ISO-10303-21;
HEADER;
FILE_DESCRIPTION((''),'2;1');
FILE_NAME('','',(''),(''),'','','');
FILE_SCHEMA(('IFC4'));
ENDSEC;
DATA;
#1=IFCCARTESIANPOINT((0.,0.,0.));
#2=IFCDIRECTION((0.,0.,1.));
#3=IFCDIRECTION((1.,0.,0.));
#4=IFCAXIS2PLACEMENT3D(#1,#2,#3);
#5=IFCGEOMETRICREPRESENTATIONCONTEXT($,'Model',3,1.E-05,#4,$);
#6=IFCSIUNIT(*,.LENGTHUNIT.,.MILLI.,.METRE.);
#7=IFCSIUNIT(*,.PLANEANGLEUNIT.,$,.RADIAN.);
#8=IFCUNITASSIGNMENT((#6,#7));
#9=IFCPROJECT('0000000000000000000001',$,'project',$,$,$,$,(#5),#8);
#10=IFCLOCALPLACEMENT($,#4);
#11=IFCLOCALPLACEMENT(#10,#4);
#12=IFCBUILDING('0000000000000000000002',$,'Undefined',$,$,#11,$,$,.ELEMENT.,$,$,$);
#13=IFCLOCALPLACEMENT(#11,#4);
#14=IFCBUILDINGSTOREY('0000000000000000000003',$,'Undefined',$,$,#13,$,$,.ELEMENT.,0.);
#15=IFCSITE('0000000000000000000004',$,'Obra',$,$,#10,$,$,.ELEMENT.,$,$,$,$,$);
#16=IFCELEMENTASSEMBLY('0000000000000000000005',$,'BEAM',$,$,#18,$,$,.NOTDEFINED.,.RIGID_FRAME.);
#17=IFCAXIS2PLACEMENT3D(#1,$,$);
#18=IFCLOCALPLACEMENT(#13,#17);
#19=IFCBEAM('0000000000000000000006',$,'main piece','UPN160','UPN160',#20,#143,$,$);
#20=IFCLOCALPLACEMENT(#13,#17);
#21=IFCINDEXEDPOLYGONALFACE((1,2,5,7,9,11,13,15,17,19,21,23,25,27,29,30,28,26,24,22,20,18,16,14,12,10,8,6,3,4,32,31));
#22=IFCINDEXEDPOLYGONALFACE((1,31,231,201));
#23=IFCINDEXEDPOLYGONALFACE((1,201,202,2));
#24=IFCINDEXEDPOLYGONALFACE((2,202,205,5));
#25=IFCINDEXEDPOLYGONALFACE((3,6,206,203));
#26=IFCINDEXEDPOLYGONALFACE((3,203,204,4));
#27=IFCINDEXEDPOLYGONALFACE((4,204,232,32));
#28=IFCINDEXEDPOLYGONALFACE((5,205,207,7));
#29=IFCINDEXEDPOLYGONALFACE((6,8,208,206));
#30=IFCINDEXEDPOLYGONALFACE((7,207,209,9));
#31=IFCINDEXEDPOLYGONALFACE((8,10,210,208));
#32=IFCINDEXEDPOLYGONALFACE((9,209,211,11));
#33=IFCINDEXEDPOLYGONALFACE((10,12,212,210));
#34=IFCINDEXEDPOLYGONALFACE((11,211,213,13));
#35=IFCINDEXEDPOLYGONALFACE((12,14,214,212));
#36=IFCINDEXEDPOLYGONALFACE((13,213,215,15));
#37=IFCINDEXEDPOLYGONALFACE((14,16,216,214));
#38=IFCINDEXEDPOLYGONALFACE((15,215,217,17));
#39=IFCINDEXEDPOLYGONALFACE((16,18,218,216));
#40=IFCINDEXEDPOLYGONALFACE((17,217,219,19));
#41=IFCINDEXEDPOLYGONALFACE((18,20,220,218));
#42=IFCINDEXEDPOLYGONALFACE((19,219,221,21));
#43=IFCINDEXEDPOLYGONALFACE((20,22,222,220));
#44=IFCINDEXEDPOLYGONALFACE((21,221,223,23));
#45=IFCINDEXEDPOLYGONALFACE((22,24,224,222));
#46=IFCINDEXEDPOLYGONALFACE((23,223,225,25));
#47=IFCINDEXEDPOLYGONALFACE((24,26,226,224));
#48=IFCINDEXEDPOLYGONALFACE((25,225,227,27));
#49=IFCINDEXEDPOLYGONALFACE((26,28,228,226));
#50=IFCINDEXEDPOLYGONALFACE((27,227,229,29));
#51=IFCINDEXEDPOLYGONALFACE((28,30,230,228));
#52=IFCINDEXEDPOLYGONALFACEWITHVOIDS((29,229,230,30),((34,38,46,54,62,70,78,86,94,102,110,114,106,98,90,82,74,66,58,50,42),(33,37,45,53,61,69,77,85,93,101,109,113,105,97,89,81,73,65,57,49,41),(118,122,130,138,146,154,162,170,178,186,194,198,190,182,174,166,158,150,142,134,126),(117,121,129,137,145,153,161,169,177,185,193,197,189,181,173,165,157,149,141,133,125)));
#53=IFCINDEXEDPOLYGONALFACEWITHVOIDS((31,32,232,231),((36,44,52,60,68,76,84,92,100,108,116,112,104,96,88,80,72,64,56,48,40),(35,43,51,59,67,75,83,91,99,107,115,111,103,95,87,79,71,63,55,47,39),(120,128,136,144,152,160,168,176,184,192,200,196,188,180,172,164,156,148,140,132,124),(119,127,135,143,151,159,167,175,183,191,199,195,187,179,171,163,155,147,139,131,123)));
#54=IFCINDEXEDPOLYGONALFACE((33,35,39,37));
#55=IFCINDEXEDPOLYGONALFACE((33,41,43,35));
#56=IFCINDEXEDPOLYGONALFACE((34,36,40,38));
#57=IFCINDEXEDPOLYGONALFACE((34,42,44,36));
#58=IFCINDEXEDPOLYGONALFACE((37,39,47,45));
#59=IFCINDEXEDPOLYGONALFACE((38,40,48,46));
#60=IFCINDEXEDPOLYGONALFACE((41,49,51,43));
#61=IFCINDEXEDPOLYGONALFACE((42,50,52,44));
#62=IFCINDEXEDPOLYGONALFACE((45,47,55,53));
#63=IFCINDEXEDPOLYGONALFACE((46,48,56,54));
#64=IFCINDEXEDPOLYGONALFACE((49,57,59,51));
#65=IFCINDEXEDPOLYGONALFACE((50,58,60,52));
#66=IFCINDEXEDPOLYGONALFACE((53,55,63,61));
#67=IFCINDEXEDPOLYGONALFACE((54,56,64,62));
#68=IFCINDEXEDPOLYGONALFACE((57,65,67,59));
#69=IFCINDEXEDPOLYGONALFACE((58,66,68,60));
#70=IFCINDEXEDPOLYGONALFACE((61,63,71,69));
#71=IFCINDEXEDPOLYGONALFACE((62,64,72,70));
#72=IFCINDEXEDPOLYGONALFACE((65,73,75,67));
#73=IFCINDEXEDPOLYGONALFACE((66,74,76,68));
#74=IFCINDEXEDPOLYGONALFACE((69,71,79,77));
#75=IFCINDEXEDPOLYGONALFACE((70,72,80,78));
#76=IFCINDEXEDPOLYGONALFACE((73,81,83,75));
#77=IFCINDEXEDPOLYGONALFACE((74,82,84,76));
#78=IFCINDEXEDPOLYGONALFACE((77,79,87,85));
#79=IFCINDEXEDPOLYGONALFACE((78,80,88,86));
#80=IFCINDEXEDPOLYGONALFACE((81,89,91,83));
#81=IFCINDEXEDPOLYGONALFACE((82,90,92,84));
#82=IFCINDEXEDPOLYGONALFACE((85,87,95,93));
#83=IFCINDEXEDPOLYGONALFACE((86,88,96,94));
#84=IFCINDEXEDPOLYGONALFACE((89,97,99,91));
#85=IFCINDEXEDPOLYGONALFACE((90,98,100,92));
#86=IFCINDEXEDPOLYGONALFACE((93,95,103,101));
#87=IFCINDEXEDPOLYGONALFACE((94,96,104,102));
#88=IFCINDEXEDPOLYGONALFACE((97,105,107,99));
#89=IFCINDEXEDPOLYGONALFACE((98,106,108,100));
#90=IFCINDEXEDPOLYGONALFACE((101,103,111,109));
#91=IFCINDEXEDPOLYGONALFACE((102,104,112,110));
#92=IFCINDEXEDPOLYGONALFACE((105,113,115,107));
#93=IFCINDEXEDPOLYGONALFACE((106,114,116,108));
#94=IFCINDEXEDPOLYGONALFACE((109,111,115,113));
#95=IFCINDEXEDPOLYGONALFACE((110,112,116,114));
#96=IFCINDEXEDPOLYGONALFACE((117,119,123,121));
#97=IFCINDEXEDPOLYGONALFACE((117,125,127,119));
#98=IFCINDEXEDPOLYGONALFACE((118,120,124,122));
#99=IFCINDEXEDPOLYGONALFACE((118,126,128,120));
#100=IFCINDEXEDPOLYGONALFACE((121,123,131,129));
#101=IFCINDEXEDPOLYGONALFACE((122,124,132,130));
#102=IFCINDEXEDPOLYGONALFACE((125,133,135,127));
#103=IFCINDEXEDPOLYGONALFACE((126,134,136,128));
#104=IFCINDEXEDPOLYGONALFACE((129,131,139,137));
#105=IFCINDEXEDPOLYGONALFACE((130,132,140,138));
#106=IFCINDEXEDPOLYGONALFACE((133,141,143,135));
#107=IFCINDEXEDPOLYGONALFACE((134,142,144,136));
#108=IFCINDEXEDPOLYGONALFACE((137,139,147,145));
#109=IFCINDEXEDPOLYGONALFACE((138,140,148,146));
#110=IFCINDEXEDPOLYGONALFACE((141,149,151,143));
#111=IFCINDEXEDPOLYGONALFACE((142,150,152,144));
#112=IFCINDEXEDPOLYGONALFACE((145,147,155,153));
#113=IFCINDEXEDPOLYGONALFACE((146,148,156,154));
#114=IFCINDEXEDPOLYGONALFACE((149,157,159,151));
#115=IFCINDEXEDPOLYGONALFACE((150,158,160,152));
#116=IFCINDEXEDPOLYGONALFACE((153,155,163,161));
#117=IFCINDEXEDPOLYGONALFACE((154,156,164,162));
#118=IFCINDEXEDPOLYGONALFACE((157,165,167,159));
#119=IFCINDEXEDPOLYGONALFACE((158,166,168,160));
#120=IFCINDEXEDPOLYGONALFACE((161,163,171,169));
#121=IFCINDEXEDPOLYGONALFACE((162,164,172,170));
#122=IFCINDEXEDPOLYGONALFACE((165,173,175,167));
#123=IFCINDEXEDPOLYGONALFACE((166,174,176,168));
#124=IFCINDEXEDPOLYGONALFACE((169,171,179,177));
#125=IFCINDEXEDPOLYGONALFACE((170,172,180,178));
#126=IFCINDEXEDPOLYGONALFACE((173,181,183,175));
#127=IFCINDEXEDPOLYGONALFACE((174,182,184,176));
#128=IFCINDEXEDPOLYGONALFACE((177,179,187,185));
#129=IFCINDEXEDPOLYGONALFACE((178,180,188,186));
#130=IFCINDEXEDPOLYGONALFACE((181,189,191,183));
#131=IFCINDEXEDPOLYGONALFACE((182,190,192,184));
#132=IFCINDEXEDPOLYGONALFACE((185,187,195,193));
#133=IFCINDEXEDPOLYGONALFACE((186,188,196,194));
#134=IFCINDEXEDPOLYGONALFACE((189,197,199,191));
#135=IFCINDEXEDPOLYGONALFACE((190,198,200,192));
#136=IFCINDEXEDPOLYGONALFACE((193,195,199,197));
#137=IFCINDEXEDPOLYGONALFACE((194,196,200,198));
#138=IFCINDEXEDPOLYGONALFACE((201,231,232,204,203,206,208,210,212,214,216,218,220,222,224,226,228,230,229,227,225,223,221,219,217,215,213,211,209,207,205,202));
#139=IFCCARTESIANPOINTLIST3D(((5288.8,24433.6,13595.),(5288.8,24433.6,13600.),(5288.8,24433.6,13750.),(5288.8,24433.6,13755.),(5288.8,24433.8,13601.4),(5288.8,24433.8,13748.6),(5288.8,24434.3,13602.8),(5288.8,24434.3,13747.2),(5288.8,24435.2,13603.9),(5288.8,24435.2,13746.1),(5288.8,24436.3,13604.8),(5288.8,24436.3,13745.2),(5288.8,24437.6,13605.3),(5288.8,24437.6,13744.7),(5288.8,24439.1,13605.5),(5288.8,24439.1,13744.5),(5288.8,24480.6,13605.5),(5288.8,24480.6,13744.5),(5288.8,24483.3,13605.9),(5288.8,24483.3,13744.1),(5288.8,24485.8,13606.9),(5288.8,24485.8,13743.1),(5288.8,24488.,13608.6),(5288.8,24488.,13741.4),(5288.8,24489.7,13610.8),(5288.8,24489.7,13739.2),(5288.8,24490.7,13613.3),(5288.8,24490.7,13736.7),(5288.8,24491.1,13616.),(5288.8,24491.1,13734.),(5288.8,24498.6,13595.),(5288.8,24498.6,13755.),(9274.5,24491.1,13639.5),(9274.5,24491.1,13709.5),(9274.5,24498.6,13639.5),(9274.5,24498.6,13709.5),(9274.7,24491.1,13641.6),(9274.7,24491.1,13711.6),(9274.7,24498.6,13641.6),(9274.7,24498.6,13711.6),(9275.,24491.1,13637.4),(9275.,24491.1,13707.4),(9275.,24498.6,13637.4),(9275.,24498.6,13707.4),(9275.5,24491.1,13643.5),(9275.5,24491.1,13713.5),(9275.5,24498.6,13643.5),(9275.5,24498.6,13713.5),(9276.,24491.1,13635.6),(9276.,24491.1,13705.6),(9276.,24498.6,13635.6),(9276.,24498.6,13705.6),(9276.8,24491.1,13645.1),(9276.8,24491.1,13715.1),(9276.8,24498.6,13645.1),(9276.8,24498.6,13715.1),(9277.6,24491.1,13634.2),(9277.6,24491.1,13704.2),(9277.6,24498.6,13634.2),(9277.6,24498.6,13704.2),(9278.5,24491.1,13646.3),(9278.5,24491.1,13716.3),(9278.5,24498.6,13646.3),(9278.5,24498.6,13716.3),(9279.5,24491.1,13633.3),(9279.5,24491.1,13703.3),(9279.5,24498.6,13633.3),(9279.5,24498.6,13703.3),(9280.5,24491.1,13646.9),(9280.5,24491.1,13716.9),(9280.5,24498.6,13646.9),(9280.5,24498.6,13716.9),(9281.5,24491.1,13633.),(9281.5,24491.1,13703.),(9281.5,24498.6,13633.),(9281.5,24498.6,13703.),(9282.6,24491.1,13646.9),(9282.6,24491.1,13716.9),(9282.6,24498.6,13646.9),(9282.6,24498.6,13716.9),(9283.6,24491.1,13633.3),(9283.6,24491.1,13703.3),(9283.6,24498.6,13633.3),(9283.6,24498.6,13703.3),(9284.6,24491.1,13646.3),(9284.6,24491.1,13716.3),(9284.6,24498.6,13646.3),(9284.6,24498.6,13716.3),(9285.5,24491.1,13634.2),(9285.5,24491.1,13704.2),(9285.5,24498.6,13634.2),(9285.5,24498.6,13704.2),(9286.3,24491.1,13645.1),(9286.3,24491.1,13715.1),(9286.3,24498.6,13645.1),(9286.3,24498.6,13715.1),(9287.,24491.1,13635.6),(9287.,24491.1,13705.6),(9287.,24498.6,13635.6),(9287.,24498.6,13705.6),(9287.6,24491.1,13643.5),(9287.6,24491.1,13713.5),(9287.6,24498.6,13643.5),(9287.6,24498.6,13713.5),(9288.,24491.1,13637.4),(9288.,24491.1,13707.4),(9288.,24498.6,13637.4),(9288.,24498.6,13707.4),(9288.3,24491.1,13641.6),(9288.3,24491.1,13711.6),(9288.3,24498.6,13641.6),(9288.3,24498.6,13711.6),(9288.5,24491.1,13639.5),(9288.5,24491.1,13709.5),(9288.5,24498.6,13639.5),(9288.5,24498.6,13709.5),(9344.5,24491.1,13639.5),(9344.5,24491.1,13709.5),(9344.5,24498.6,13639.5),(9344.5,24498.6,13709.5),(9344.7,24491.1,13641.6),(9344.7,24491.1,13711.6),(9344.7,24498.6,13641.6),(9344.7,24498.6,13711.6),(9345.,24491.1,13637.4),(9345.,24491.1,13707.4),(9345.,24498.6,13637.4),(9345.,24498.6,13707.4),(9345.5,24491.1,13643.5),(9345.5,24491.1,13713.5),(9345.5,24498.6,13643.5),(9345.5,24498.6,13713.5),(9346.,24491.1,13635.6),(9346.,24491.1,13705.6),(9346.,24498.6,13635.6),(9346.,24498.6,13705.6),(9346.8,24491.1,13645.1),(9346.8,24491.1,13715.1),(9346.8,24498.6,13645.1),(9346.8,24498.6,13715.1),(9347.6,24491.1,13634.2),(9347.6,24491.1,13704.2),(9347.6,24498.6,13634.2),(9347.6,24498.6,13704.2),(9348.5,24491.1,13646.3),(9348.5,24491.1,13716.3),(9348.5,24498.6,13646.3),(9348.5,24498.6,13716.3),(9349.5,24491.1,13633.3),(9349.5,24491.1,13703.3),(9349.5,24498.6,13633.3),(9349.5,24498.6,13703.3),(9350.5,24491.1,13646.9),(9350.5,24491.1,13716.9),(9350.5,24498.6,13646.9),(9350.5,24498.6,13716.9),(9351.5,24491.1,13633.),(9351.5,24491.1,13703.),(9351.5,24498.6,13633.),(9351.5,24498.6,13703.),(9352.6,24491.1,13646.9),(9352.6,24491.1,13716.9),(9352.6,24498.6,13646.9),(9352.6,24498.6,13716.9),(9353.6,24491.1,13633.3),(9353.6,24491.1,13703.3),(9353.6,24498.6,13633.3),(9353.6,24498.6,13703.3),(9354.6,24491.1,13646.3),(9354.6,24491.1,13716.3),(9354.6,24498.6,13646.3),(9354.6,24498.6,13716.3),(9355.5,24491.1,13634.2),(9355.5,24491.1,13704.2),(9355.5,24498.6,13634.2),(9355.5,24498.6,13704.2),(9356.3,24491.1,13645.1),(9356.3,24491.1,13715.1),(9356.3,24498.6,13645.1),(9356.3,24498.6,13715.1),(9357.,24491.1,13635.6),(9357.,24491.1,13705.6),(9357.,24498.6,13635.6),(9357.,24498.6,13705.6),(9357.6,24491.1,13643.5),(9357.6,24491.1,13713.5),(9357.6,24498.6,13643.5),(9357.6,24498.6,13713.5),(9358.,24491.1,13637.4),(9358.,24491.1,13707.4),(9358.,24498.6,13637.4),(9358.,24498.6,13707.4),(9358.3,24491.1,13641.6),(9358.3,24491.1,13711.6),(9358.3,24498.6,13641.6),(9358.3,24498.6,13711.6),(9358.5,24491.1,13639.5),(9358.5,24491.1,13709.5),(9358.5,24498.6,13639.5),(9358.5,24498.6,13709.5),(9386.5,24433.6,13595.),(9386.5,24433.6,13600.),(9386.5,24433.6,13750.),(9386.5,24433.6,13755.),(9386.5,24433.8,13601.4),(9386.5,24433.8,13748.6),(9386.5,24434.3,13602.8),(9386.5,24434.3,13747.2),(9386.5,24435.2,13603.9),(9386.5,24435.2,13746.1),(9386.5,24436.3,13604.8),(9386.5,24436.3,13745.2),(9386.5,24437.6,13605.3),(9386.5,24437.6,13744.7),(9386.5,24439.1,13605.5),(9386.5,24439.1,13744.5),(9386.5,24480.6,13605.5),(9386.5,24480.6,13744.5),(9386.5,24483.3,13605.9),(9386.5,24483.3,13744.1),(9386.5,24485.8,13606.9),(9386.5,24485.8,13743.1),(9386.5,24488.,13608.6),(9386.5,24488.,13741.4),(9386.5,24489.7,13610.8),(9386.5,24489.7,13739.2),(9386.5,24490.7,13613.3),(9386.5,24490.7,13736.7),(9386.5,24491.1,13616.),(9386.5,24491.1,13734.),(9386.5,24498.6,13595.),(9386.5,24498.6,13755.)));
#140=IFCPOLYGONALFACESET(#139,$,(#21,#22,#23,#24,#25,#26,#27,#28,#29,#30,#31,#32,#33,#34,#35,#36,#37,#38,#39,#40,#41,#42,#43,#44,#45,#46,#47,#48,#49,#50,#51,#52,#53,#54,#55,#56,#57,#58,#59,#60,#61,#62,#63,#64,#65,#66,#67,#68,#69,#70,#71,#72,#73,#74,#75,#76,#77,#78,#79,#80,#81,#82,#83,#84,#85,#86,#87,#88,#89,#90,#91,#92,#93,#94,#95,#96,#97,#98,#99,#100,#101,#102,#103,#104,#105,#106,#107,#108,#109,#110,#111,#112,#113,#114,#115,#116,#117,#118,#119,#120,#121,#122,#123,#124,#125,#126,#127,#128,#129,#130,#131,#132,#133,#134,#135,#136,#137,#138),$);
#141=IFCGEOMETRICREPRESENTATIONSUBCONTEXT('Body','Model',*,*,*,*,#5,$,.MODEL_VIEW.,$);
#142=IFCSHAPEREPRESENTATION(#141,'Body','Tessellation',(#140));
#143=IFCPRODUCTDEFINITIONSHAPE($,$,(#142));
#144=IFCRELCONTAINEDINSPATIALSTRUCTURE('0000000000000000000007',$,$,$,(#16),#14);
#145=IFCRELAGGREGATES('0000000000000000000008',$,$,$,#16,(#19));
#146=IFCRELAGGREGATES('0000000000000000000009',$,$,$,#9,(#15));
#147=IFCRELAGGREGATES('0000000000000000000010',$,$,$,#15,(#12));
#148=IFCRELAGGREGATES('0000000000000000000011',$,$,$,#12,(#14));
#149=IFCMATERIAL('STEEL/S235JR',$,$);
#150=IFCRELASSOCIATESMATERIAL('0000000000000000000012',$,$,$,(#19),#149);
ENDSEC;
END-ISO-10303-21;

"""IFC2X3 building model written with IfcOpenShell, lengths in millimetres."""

from ifc_helpers import new_model, si_unit, frame, origin_with_axes, origin_2d_with_axis, place, context, subcontext, project, spatial, circle, u_section, extrude, clip, halfspace, source, transform, mapped, material, element, aggregate, save


model = new_model("IFC2X3")

# Units and contexts
model_context = context("Model", 3, precision=1e-05, world=origin_with_axes())
body_context = subcontext(model_context, "Body", "Model", "MODEL_VIEW")
ifc_project = project(units=[si_unit("LENGTHUNIT", "METRE", prefix="MILLI"), si_unit("PLANEANGLEUNIT", "RADIAN")], contexts=[model_context])

# Site, building, storey
site_placement = place(None, origin_with_axes())
site = spatial("IfcSite", under=ifc_project, at=site_placement, Name="Obra", CompositionType="ELEMENT")
building_placement = place(site_placement, origin_with_axes())
building = spatial("IfcBuilding", under=site, at=building_placement, Name="Undefined", CompositionType="ELEMENT")
storey_placement = place(building_placement, origin_with_axes())
storey = spatial("IfcBuildingStorey", under=building, at=storey_placement, Name="Undefined", CompositionType="ELEMENT", Elevation=0.0)

# Shared definitions
ifc_material_1 = material(Name="STEEL/S235JR")

# Element assembly, beam, opening
shared_shape_1 = source(origin_with_axes(), body_context, "Body", "SweptSolid", [
    extrude(circle(Radius=7.0, at=origin_2d_with_axis()), frame((0.0, -3.9, 0.0), z_axis=(0.0, 1.0, 0.0), x_axis=(1.0, 0.0, 0.0)), (0.0, 0.0, 1.0), 7.7),
])
assembly_1_placement = place(storey_placement, origin_with_axes())
assembly_1 = element("IfcElementAssembly", 1, at=assembly_1_placement, inside=storey, Name="BEAM", AssemblyPlace="NOTDEFINED", PredefinedType="RIGID_FRAME")
beam_1_placement = place(assembly_1_placement, frame((5288.8, 24466.1, 13675.0), z_axis=(0.0, 0.0, 1.0), x_axis=(1.0, 0.0, 0.0)))
beam_1 = element("IfcBeam", 2, at=beam_1_placement, material=ifc_material_1, Name="main piece", Description="UPN160", ObjectType="UPN160", context=body_context, shape_type="Clipping", body=[
    clip(extrude(u_section(Depth=160.0, FlangeWidth=65.0, WebThickness=7.5, FlangeThickness=10.5, FilletRadius=10.5, EdgeRadius=5.5, at=origin_2d_with_axis()), frame((4097.7, 0.0, 0.0), z_axis=(-1.0, 0.0, 0.0), x_axis=(0.0, -1.0, 0.0)), (0.0, 0.0, 1.0), 4097.7), halfspace(frame((4097.7, 0.0, 166.3), z_axis=(1.0, 0.0, 0.0), x_axis=(0.0, 1.0, 0.0)), False)),
])
opening_1_placement = place(assembly_1_placement, frame((9351.5, 24494.8, 13710.0), z_axis=(-1.0, 0.0, 0.0), x_axis=(0.0, 0.0, -1.0)))
element("IfcOpeningElement", 3, at=opening_1_placement, cuts=beam_1, ObjectType="Opening", context=body_context, shape_type="MappedRepresentation", body=[
    mapped(shared_shape_1, transform((0.0, 0.0, 0.0))),
    mapped(shared_shape_1, transform((0.0, 0.0, 70.0))),
    mapped(shared_shape_1, transform((70.0, 0.0, 0.0))),
    mapped(shared_shape_1, transform((70.0, 0.0, 70.0))),
])
aggregate(assembly_1, [beam_1])

save(model, "model.ifc")
